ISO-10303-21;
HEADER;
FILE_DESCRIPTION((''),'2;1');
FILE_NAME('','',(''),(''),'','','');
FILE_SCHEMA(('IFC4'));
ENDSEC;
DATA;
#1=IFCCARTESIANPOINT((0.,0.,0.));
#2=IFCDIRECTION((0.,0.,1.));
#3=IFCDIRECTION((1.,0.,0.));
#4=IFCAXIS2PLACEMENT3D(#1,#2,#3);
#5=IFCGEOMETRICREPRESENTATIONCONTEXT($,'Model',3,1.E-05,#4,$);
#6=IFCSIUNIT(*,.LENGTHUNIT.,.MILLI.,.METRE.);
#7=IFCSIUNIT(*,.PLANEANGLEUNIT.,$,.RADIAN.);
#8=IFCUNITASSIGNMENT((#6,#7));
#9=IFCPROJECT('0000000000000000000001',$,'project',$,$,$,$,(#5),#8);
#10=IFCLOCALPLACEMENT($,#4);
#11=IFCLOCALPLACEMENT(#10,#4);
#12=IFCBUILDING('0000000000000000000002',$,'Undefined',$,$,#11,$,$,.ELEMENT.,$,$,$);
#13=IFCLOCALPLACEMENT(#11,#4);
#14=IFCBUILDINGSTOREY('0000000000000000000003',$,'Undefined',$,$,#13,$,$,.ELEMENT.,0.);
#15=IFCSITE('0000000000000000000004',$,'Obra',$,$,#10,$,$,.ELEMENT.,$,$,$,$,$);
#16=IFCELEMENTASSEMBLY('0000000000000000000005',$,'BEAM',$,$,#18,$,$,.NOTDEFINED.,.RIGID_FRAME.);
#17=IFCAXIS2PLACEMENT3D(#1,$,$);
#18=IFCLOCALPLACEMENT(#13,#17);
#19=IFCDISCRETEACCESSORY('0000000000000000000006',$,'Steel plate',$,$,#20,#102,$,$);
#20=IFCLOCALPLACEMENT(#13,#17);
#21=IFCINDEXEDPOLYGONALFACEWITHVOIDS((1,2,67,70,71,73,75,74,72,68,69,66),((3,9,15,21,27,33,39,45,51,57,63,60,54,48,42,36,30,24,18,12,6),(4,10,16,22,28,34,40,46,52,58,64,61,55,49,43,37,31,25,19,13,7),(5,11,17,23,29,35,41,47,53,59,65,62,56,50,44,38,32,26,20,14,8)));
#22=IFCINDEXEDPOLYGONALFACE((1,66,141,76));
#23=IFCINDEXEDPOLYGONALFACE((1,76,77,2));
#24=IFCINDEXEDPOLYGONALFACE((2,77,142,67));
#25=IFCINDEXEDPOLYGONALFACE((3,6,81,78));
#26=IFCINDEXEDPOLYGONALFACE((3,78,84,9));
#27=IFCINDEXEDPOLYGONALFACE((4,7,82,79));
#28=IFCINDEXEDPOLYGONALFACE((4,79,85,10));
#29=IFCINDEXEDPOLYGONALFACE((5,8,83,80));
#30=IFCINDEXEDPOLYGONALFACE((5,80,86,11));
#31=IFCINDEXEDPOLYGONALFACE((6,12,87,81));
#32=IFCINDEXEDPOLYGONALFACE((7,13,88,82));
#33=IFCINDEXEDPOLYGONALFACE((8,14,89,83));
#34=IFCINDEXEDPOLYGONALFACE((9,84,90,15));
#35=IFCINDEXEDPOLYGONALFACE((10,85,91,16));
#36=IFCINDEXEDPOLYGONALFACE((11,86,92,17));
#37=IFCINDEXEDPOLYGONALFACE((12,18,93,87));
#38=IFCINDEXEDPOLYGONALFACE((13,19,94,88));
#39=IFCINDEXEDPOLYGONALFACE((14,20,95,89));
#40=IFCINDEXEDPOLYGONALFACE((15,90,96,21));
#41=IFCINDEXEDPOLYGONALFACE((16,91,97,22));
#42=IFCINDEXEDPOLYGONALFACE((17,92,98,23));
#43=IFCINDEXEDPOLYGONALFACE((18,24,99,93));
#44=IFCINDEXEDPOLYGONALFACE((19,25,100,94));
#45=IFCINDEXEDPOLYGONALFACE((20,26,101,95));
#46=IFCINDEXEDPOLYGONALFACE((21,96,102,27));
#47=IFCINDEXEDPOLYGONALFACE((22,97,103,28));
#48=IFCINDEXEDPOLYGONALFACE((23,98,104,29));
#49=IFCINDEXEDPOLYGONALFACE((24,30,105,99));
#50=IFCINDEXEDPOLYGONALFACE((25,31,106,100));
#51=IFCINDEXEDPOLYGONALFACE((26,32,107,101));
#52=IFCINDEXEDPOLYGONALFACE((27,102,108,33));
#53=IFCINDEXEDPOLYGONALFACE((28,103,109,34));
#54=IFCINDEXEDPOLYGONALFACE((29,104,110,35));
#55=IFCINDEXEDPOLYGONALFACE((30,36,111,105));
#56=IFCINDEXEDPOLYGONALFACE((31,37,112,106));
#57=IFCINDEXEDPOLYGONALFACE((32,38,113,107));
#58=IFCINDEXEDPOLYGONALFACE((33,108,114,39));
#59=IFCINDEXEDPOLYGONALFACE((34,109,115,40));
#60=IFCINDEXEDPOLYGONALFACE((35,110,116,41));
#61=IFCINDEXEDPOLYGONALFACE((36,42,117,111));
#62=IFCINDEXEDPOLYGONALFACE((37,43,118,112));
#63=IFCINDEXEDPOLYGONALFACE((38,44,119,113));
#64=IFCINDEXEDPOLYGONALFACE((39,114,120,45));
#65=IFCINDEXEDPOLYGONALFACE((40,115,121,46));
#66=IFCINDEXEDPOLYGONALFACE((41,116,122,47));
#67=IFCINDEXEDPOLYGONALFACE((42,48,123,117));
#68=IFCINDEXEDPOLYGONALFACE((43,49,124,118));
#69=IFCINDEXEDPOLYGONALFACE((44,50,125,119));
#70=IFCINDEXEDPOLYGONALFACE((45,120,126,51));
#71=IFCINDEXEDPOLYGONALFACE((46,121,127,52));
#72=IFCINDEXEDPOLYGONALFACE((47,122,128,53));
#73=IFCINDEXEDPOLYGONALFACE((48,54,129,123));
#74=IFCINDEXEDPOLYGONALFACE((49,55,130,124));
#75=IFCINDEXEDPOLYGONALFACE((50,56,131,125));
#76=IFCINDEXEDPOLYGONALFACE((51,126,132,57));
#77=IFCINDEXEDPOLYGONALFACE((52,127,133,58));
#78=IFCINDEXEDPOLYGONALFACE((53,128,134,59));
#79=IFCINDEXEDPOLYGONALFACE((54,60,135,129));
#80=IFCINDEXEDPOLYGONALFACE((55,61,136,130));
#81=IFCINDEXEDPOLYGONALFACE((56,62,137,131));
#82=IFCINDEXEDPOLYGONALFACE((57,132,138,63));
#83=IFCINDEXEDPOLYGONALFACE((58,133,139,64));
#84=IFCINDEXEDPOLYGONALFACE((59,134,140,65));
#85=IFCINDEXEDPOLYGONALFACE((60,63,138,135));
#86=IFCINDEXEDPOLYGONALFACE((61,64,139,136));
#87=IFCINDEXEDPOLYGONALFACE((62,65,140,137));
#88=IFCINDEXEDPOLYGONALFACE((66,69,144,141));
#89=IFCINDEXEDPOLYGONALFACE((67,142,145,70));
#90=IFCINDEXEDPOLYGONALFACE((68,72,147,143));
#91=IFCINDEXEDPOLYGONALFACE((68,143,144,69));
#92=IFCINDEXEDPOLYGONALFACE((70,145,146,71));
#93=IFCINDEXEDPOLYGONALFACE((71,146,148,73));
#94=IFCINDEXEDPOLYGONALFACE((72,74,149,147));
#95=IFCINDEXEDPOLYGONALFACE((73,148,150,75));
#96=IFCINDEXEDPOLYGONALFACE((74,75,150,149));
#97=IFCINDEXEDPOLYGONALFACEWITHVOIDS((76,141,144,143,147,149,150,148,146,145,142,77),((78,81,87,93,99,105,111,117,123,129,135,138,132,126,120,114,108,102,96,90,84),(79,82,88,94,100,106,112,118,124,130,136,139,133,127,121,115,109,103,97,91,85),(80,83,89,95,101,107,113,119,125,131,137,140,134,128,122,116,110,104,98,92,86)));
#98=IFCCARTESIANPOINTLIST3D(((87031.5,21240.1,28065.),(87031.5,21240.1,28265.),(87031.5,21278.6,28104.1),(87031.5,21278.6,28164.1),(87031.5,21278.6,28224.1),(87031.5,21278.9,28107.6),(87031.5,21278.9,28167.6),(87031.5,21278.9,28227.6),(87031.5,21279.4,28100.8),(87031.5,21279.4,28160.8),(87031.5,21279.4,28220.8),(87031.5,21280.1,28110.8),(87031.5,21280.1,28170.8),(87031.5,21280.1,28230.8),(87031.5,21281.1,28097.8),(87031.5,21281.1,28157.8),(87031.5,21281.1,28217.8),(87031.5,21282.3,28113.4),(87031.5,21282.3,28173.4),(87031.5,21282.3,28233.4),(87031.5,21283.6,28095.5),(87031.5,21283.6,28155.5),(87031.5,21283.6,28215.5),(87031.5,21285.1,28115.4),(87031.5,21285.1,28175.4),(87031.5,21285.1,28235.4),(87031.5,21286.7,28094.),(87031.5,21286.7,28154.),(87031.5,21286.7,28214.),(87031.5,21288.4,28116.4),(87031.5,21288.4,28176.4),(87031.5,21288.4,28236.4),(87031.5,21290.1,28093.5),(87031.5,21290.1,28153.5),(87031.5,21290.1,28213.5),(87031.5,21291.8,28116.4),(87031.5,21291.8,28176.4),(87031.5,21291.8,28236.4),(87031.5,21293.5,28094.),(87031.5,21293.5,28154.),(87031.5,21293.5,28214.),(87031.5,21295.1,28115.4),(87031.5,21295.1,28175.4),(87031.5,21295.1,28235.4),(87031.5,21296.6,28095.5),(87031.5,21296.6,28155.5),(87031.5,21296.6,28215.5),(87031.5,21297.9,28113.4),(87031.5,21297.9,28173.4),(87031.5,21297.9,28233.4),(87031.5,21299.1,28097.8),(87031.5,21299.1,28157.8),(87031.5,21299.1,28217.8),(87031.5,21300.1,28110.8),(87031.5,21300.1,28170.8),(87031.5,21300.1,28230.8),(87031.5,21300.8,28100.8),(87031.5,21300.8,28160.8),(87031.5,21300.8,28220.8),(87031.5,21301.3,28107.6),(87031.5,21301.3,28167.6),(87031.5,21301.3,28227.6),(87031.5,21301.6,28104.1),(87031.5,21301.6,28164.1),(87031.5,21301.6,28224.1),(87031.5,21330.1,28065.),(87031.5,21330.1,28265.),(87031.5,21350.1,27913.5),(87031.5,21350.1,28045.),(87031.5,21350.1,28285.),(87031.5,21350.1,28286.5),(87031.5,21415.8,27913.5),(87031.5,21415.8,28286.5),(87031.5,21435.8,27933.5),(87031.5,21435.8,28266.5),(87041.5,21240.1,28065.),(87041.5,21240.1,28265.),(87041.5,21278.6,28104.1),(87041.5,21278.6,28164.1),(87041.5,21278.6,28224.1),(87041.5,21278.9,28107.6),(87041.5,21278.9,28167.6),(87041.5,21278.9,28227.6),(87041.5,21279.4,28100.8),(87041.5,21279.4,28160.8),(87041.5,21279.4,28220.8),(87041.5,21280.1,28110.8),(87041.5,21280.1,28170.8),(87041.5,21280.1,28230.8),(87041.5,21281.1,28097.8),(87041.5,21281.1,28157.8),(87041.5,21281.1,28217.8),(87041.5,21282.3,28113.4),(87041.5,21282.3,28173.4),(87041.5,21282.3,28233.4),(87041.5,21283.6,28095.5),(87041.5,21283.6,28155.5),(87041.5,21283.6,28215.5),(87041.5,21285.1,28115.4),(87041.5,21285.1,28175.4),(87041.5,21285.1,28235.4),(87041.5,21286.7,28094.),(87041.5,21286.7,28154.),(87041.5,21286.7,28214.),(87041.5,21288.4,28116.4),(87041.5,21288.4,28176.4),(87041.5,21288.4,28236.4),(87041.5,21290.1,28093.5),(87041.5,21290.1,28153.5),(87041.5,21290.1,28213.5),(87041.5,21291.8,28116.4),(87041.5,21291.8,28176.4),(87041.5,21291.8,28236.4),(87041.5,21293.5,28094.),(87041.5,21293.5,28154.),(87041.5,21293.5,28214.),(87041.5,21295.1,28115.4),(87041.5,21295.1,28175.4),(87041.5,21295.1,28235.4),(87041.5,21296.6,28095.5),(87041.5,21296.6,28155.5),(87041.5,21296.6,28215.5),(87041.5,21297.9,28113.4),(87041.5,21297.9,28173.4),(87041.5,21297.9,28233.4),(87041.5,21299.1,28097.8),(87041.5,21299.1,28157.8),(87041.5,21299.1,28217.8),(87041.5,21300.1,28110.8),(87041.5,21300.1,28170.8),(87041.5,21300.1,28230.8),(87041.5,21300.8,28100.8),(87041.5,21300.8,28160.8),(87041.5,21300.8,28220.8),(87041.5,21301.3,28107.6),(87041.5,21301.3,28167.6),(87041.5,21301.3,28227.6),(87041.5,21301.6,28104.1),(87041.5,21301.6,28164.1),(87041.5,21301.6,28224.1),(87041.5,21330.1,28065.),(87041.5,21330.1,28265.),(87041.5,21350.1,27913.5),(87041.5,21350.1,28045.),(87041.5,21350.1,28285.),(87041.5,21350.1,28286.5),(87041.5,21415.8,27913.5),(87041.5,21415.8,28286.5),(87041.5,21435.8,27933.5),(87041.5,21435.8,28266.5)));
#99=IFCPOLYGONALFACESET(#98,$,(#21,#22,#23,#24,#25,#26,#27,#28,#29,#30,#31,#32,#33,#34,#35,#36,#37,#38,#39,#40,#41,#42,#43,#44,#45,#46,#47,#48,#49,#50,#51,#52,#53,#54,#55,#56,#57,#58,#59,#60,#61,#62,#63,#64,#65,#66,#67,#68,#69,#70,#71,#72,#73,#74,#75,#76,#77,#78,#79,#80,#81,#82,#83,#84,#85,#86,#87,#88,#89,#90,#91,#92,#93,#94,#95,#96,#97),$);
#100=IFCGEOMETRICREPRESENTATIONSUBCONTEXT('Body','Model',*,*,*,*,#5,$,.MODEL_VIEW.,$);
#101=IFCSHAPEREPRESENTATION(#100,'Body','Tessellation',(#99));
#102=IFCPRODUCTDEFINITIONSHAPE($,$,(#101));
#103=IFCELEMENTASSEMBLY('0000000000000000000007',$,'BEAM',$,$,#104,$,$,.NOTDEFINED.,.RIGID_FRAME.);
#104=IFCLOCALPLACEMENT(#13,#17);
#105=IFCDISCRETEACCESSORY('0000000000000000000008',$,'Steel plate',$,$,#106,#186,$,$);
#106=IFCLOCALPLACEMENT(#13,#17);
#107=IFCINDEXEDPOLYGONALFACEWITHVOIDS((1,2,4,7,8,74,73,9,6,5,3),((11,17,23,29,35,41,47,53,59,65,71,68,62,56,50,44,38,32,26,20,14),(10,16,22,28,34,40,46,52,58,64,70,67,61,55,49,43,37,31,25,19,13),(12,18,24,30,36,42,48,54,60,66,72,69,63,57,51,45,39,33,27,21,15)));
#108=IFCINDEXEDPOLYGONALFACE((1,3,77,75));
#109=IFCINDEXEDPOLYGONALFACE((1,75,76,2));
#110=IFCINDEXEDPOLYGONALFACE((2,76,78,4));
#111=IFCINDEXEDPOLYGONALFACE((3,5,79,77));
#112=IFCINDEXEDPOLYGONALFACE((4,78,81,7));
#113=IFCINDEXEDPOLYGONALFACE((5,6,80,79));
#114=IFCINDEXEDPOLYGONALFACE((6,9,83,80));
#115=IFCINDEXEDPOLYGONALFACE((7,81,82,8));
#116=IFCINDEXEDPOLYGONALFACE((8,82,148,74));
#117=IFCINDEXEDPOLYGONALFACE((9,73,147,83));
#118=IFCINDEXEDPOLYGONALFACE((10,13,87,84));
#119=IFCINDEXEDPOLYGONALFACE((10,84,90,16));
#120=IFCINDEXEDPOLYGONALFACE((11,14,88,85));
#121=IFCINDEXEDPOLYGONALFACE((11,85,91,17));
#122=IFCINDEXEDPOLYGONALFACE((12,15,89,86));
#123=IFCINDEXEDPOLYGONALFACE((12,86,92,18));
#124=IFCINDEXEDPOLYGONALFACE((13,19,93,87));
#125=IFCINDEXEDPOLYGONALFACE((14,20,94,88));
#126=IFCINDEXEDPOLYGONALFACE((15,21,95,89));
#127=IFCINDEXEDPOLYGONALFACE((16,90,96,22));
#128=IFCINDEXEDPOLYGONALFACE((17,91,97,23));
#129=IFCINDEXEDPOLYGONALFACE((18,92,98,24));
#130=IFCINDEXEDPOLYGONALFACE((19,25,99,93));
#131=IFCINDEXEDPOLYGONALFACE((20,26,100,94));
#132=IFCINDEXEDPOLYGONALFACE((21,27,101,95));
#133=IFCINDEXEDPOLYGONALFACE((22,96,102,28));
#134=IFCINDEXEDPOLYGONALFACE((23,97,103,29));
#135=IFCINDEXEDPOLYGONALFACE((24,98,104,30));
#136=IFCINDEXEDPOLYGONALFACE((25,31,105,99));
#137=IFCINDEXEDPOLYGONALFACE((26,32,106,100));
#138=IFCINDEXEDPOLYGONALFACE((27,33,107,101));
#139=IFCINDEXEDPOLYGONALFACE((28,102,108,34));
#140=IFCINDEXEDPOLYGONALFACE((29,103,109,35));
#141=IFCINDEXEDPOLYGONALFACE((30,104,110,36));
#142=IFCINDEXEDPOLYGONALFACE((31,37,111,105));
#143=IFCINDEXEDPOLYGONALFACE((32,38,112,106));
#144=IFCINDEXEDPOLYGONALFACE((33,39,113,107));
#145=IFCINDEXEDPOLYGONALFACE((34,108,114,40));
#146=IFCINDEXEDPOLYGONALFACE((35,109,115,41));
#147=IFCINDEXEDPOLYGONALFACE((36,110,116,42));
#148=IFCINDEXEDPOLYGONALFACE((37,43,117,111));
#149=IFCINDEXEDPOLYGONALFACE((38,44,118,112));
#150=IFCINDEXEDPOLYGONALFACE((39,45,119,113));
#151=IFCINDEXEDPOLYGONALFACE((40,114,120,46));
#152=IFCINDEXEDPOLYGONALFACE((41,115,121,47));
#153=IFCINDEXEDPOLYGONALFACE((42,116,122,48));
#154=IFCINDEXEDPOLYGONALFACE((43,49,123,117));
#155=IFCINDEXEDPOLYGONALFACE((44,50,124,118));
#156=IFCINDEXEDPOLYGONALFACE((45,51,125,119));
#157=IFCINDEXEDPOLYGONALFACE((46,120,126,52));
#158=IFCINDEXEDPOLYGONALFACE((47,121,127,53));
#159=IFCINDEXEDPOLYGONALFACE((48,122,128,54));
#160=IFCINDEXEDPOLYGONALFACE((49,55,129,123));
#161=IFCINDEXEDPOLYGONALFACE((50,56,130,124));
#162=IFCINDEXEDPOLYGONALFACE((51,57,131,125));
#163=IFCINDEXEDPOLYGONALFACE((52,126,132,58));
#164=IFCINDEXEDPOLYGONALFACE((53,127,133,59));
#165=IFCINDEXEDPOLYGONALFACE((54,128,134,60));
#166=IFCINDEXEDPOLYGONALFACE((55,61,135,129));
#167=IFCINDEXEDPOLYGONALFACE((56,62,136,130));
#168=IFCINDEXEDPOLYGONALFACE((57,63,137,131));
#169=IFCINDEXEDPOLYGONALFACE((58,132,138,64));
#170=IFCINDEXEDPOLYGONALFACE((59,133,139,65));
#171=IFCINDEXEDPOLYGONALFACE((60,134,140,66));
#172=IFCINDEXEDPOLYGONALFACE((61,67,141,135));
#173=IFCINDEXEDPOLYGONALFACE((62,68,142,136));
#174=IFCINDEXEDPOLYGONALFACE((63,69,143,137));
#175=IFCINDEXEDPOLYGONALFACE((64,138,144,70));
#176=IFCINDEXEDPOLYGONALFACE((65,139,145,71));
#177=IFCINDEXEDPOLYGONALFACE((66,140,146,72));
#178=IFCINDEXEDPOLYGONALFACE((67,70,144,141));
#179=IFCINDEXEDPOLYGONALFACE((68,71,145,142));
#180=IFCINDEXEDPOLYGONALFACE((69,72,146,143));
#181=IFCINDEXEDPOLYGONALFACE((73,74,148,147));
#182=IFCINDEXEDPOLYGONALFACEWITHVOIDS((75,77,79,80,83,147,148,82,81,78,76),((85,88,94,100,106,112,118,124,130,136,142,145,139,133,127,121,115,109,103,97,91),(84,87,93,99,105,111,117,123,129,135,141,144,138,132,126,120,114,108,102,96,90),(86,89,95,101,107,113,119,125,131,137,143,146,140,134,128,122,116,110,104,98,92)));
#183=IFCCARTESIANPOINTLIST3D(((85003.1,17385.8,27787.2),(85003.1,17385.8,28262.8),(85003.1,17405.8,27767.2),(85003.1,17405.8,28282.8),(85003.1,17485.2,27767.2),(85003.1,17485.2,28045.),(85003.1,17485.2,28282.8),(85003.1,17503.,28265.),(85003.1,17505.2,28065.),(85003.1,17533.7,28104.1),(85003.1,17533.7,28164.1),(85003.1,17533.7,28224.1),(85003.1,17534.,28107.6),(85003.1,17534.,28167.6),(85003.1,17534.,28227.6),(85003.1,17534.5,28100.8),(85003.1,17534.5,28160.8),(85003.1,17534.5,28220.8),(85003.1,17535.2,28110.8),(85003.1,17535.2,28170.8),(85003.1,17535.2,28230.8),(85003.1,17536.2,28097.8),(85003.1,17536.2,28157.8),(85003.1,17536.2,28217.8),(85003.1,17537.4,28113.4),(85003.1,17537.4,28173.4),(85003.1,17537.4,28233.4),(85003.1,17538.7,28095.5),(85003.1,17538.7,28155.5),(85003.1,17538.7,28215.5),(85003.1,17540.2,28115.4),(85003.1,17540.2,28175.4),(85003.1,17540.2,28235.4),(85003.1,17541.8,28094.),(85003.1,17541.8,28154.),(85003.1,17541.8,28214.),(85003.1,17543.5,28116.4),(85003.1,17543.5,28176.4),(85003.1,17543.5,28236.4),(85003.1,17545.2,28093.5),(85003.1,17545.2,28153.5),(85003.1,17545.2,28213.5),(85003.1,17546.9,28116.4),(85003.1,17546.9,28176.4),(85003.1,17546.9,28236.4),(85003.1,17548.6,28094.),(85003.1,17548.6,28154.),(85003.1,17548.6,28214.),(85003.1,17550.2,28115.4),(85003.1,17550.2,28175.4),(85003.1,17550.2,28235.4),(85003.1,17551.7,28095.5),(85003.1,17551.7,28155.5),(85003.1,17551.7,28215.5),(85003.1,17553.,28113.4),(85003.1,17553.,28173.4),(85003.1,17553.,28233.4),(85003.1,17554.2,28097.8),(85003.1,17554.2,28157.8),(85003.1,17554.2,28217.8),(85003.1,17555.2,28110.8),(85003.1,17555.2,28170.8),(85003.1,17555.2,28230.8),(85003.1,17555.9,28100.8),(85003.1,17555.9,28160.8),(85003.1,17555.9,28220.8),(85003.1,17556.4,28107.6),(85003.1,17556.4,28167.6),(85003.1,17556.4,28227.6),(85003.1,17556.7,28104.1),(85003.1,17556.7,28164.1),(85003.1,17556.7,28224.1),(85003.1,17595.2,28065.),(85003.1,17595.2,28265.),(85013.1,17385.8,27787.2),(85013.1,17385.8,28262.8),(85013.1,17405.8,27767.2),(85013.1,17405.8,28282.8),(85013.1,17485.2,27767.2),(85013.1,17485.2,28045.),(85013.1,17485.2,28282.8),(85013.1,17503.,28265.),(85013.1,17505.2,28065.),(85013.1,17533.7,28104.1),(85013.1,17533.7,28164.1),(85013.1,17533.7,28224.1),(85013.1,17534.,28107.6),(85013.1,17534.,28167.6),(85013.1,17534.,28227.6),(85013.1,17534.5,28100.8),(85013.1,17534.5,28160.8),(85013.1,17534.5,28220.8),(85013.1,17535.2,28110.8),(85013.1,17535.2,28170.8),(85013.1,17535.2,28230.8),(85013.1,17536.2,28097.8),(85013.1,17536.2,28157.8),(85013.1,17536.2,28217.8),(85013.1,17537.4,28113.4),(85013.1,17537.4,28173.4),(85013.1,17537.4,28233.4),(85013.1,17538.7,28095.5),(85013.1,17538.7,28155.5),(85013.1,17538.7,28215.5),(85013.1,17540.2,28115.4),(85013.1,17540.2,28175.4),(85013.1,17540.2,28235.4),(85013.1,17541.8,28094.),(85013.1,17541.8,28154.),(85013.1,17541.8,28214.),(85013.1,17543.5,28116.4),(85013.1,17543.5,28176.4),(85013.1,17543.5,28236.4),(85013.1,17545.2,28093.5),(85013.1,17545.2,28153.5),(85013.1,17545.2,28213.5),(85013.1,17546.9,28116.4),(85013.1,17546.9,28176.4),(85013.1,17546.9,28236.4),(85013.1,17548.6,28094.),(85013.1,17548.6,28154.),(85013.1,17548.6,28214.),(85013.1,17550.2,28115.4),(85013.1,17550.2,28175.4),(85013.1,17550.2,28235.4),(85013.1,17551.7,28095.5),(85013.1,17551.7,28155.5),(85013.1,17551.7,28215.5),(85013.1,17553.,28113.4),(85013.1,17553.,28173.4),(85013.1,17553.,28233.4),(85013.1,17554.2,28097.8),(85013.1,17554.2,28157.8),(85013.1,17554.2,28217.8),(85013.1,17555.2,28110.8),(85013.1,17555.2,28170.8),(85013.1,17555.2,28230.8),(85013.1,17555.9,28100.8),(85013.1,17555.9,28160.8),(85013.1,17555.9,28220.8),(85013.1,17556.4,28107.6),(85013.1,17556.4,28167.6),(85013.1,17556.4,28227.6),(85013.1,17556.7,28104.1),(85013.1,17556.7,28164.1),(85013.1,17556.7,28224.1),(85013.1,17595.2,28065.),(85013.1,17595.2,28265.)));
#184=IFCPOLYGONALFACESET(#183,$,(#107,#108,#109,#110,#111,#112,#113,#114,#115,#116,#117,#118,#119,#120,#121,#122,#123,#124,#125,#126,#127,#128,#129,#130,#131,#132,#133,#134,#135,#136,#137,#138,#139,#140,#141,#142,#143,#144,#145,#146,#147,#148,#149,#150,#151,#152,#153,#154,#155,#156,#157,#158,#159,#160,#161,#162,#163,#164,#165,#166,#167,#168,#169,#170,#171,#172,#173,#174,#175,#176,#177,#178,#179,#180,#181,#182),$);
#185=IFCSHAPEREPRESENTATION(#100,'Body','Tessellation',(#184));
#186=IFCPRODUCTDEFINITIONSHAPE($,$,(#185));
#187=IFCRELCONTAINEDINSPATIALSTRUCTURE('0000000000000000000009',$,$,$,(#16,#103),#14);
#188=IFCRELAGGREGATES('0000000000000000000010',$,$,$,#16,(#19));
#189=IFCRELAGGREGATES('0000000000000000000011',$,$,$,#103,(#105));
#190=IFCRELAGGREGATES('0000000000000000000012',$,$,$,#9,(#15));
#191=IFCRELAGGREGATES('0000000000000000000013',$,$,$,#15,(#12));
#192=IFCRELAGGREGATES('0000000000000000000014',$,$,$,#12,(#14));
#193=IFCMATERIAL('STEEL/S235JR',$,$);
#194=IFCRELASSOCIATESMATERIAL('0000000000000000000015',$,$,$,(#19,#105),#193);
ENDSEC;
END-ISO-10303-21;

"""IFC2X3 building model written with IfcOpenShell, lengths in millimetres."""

from ifc_helpers import new_model, si_unit, frame, origin_with_axes, origin_2d_with_axis, place, context, subcontext, project, spatial, polyline, circle, outline, extrude, source, transform, mapped, material, element, aggregate, save


model = new_model("IFC2X3")

# Units and contexts
model_context = context("Model", 3, precision=1e-05, world=origin_with_axes())
body_context = subcontext(model_context, "Body", "Model", "MODEL_VIEW")
ifc_project = project(units=[si_unit("LENGTHUNIT", "METRE", prefix="MILLI"), si_unit("PLANEANGLEUNIT", "RADIAN")], contexts=[model_context])

# Site, building, storey
site_placement = place(None, origin_with_axes())
site = spatial("IfcSite", under=ifc_project, at=site_placement, Name="Obra", CompositionType="ELEMENT")
building_placement = place(site_placement, origin_with_axes())
building = spatial("IfcBuilding", under=site, at=building_placement, Name="Undefined", CompositionType="ELEMENT")
storey_placement = place(building_placement, origin_with_axes())
storey = spatial("IfcBuildingStorey", under=building, at=storey_placement, Name="Undefined", CompositionType="ELEMENT", Elevation=0.0)

# Shared definitions
ifc_material = material(Name="STEEL/S235JR")

# Element assembly
assembly_1_placement = place(storey_placement, origin_with_axes())
assembly_1 = element("IfcElementAssembly", 1, at=assembly_1_placement, inside=storey, Name="BEAM", AssemblyPlace="NOTDEFINED", PredefinedType="RIGID_FRAME")

# Shared definitions
shared_shape_1 = source(origin_with_axes(), body_context, "Body", "SweptSolid", [
    extrude(circle(Radius=11.5, at=origin_2d_with_axis()), frame((0.0, -13.4, 0.0), z_axis=(0.0, 1.0, 0.0), x_axis=(1.0, 0.0, 0.0)), (0.0, 0.0, 1.0), 10.2),
])

# Discrete accessory, opening
discrete_accessory_1_placement = place(assembly_1_placement, frame((87036.5, 21435.8, 27933.5), z_axis=(-1.0, 0.0, 0.0), x_axis=(0.000001, -0.707107, -0.707107)))
discrete_accessory_1 = element("IfcDiscreteAccessory", 2, at=discrete_accessory_1_placement, material=ifc_material, Name="Steel plate", context=body_context, shape_type="SweptSolid", body=[
    extrude(outline(polyline([(0.0, 0.0), (28.3, 0.0), (74.7, 46.5), (-18.2, 139.4), (-18.2, 167.7), (45.4, 231.4), (-96.0, 372.8), (-159.7, 309.1), (-187.9, 309.1), (-189.0, 310.2), (-235.5, 263.8), (-235.5, 235.5), (0.0, 0.0)])), frame((0.0, 0.0, -5.0), z_axis=(0.0, 0.0, 1.0), x_axis=(1.0, 0.0, 0.0)), (0.0, 0.0, 1.0), 10.0),
])
opening_1_placement = place(assembly_1_placement, frame((87044.8, 21340.1, 28265.0), z_axis=(0.0, -1.0, 0.0), x_axis=(0.0, 0.0, -1.0)))
element("IfcOpeningElement", 3, at=opening_1_placement, cuts=discrete_accessory_1, ObjectType="Opening", context=body_context, shape_type="MappedRepresentation", body=[
    mapped(shared_shape_1, transform((40.0, 0.0, 50.0))),
    mapped(shared_shape_1, transform((100.0, 0.0, 50.0))),
    mapped(shared_shape_1, transform((160.0, 0.0, 50.0))),
])
aggregate(assembly_1, [discrete_accessory_1])

# Element assembly, discrete accessory, opening
assembly_2_placement = place(storey_placement, origin_with_axes())
assembly_2 = element("IfcElementAssembly", 4, at=assembly_2_placement, inside=storey, Name="BEAM", AssemblyPlace="NOTDEFINED", PredefinedType="RIGID_FRAME")
discrete_accessory_2_placement = place(assembly_2_placement, frame((85008.1, 17385.8, 27787.2), z_axis=(1.0, 0.0, 0.0), x_axis=(-0.000001, 0.707107, -0.707107)))
discrete_accessory_2 = element("IfcDiscreteAccessory", 5, at=discrete_accessory_2_placement, material=ifc_material, Name="Steel plate", context=body_context, shape_type="SweptSolid", body=[
    extrude(outline(polyline([(0.0, 0.0), (28.3, 0.0), (84.5, 56.2), (-112.0, 252.6), (-112.0, 280.9), (-48.3, 344.5), (-189.8, 486.0), (-254.9, 420.8), (-280.1, 420.8), (-280.1, 420.8), (-336.3, 364.6), (-336.3, 336.3), (0.0, 0.0)])), frame((0.0, 0.0, -5.0), z_axis=(0.0, 0.0, 1.0), x_axis=(1.0, 0.0, 0.0)), (0.0, 0.0, 1.0), 10.0),
])
shared_shape_2 = source(origin_with_axes(), body_context, "Body", "SweptSolid", [
    extrude(circle(Radius=11.5, at=origin_2d_with_axis()), frame((0.0, -13.4, 0.0), z_axis=(0.0, 1.0, 0.0), x_axis=(1.0, 0.0, 0.0)), (0.0, 0.0, 1.0), 10.2),
])
opening_2_placement = place(assembly_2_placement, frame((84999.8, 17495.2, 28265.0), z_axis=(0.0, 1.0, 0.0), x_axis=(0.0, 0.0, -1.0)))
element("IfcOpeningElement", 6, at=opening_2_placement, cuts=discrete_accessory_2, ObjectType="Opening", context=body_context, shape_type="MappedRepresentation", body=[
    mapped(shared_shape_2, transform((40.0, 0.0, 50.0))),
    mapped(shared_shape_2, transform((100.0, 0.0, 50.0))),
    mapped(shared_shape_2, transform((160.0, 0.0, 50.0))),
])
aggregate(assembly_2, [discrete_accessory_2])

save(model, "model.ifc")
